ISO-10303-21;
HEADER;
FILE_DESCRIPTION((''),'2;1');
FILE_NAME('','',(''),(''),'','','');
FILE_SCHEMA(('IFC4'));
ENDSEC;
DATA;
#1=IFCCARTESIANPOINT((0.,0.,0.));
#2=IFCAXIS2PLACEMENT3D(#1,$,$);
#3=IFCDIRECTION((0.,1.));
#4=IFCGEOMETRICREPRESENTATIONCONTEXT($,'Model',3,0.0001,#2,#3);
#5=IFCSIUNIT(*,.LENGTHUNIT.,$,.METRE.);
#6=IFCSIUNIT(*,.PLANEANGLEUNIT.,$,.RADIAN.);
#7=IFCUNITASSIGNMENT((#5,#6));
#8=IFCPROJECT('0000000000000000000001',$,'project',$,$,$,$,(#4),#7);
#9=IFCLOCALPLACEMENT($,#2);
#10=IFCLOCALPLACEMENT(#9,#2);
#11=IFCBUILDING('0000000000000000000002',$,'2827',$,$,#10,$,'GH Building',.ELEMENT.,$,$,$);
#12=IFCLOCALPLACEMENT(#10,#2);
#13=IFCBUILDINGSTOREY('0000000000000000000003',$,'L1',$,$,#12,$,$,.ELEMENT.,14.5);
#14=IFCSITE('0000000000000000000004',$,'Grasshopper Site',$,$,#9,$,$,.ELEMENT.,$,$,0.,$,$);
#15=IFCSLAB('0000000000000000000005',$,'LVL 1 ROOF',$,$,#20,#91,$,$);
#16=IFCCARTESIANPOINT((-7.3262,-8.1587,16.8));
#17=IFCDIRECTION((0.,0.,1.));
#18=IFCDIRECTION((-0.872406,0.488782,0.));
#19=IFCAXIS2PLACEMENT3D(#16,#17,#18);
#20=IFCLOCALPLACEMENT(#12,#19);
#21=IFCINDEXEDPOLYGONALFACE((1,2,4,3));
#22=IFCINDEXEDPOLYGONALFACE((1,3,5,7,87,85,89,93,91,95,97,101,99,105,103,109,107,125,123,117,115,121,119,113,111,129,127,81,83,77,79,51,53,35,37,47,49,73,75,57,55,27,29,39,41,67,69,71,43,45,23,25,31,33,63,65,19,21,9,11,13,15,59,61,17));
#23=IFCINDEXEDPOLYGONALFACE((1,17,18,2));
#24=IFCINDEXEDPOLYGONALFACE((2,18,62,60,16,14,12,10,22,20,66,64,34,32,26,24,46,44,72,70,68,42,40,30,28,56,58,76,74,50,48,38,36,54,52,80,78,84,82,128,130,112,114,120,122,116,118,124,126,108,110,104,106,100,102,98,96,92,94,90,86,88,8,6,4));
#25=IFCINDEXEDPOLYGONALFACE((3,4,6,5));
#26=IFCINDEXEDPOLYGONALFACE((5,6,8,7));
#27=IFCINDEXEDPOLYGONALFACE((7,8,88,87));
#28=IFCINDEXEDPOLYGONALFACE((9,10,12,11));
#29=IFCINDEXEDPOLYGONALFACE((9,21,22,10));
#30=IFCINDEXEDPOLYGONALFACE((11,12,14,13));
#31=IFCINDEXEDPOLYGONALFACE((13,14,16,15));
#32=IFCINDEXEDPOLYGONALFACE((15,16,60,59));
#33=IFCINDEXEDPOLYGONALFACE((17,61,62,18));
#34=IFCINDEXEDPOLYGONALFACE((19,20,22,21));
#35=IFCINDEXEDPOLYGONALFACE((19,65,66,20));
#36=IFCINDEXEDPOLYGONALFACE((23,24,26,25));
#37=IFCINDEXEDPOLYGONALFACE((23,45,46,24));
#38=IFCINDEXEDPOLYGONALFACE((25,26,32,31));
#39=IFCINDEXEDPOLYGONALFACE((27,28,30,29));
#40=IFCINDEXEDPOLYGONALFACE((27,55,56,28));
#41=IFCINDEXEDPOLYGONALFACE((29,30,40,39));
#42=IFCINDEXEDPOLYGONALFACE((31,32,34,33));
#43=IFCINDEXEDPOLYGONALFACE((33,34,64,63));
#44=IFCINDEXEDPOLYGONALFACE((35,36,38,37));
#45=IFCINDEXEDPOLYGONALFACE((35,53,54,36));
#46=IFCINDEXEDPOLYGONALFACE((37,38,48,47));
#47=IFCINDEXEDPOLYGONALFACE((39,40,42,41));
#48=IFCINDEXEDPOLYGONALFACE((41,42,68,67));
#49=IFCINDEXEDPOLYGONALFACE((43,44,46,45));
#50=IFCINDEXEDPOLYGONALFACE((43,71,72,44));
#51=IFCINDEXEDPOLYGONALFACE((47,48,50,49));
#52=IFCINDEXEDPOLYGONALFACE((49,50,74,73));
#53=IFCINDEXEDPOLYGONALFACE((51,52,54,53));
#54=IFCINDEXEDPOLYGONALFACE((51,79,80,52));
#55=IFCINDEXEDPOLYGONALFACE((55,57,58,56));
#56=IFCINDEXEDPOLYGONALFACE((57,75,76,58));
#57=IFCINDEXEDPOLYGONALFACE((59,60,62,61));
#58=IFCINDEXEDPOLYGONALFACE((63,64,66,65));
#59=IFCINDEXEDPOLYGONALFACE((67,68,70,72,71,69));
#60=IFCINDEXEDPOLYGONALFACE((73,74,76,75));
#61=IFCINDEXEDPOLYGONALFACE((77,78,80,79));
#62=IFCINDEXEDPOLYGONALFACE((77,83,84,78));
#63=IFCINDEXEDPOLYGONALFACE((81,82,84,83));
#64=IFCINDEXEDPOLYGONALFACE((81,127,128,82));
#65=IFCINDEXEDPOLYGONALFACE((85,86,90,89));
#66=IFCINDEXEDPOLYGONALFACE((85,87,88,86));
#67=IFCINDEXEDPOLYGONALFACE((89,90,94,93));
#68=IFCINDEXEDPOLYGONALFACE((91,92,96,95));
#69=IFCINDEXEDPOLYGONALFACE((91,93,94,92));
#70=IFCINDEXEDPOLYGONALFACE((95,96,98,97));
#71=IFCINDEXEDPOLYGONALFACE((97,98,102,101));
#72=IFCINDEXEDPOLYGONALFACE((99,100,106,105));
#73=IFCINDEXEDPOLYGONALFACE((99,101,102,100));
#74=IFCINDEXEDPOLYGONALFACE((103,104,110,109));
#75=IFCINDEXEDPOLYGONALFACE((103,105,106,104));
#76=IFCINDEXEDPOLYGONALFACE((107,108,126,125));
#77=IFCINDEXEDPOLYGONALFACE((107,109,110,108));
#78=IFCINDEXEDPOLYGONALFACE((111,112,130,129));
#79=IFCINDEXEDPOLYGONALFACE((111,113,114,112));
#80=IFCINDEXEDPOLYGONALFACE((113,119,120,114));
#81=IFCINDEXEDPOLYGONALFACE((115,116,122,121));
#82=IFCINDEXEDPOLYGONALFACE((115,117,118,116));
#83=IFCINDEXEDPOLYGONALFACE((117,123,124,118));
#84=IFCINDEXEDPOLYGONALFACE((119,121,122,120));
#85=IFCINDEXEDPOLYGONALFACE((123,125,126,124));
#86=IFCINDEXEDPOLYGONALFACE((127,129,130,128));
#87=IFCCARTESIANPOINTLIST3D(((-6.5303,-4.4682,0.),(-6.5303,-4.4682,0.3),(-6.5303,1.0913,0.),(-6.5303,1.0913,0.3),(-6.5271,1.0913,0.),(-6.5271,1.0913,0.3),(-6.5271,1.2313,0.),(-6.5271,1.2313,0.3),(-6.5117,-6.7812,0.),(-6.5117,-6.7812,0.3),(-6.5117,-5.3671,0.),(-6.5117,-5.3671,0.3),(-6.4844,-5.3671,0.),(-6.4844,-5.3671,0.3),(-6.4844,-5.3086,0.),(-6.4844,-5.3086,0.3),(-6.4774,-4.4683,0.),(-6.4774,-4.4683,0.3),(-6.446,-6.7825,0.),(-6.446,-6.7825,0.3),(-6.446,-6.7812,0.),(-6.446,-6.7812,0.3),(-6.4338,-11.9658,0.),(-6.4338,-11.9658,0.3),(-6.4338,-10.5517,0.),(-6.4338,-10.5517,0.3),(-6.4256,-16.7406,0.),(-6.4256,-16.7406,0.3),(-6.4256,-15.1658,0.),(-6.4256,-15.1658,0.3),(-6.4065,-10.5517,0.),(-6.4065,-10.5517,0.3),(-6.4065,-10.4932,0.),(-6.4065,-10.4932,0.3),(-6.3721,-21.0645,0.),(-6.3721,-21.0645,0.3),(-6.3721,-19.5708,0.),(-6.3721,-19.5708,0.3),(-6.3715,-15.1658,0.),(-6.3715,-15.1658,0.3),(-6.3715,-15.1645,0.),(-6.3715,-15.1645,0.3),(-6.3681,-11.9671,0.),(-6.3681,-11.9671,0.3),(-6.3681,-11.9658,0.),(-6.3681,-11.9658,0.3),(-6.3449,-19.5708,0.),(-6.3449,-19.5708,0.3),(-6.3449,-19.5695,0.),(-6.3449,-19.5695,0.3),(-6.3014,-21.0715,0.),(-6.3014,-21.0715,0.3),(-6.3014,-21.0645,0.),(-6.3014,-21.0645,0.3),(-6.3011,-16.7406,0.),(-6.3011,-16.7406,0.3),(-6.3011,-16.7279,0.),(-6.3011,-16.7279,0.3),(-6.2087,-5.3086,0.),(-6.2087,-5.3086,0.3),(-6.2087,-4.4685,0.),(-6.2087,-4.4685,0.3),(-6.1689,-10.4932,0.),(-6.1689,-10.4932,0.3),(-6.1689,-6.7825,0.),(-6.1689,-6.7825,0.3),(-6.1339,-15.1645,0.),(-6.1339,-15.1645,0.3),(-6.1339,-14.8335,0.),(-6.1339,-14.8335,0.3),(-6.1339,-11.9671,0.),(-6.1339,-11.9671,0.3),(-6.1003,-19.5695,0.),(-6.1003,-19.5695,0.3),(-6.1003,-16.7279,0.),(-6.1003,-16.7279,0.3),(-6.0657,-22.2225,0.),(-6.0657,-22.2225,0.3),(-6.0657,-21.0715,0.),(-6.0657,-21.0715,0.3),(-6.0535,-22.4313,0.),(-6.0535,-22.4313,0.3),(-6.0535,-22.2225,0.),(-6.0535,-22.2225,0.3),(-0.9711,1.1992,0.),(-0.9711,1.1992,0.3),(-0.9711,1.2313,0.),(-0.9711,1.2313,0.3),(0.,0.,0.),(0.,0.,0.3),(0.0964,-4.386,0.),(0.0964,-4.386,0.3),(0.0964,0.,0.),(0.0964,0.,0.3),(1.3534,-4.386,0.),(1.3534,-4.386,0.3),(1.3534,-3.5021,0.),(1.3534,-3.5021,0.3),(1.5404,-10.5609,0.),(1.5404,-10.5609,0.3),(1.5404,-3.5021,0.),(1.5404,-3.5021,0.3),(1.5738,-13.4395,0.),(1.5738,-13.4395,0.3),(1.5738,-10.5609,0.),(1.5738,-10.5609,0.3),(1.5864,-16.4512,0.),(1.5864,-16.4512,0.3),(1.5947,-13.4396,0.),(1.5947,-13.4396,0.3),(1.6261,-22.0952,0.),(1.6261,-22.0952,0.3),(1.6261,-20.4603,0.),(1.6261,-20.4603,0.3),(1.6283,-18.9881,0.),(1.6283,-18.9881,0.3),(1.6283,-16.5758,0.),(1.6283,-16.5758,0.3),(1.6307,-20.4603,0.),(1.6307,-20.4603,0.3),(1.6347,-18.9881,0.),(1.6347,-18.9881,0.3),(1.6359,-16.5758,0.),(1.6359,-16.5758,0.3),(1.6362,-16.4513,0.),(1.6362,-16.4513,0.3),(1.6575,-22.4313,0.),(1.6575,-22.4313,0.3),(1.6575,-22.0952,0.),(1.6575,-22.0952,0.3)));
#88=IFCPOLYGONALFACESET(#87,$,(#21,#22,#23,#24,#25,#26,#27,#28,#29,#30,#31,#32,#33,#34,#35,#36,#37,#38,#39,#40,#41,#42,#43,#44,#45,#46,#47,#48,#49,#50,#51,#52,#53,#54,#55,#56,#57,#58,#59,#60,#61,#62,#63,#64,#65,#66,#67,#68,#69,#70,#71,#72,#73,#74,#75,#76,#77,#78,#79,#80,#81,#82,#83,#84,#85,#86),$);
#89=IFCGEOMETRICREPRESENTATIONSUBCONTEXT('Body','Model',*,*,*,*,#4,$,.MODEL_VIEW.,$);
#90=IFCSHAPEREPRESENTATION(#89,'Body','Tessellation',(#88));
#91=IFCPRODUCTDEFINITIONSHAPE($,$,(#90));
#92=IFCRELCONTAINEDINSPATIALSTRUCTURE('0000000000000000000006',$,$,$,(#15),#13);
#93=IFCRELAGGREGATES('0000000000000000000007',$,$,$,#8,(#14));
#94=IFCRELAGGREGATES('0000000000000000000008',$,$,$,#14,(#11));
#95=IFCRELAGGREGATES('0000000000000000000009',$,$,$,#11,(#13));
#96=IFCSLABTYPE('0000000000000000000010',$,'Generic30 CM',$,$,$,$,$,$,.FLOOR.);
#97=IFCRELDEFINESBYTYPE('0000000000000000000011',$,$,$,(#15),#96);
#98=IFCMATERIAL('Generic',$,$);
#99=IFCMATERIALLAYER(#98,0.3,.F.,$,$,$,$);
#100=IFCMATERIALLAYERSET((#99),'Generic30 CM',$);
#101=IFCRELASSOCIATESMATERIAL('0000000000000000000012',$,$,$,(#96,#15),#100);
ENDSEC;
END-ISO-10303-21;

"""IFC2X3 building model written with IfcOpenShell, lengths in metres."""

from ifc_helpers import new_model, si_unit, direction, frame, origin, place, context, subcontext, project, spatial, polyline, outline, extrude, material, layer, layer_set, layer_usage, type_object, element, save


model = new_model("IFC2X3")

# Units and contexts
model_context = context("Model", 3, precision=0.0001, world=origin(), true_north=direction((0.0, 1.0)))
body_context = subcontext(model_context, "Body", "Model", "MODEL_VIEW")
ifc_project = project(units=[si_unit("LENGTHUNIT", "METRE"), si_unit("PLANEANGLEUNIT", "RADIAN")], contexts=[model_context])

# Site, building, storey
site_placement = place(None, origin())
site = spatial("IfcSite", under=ifc_project, at=site_placement, Name="Grasshopper Site", CompositionType="ELEMENT", RefElevation=0.0)
building_placement = place(site_placement, origin())
building = spatial("IfcBuilding", under=site, at=building_placement, Name="2827", LongName="GH Building", CompositionType="ELEMENT")
storey_placement = place(building_placement, origin())
storey = spatial("IfcBuildingStorey", under=building, at=storey_placement, Name="L1", CompositionType="ELEMENT", Elevation=14.5)

# Slab
ifc_material_1 = material(Name="Generic")
ifc_layer_1 = layer(ifc_material_1, 0.3, ventilated=False)
ifc_layer_set_1 = layer_set([ifc_layer_1], Name="Generic30 CM")
ifc_layer_usage_1 = layer_usage(ifc_layer_set_1, "AXIS3", "NEGATIVE", -0.3)
slab_type_1 = type_object("IfcSlabType", Name="Generic30 CM", PredefinedType="FLOOR", material=ifc_layer_set_1)
slab_1_placement = place(storey_placement, frame((-7.3262, -8.1587, 16.8), z_axis=(0.0, 0.0, 1.0), x_axis=(-0.872406, 0.488782, 0.0)))
element("IfcSlab", 1, at=slab_1_placement, inside=storey, type_object=slab_type_1, material=ifc_layer_usage_1, Name="LVL 1 ROOF", context=body_context, shape_type="SweptSolid", body=[
    extrude(outline(polyline([(0.0, 0.0), (0.0964, 0.0), (0.0964, -4.386), (1.3534, -4.386), (1.3534, -3.5021), (1.5404, -3.5021), (1.5404, -10.5609), (1.5738, -10.5609), (1.5738, -13.4395), (1.5947, -13.4396), (1.5864, -16.4512), (1.6362, -16.4513), (1.6359, -16.5758), (1.6283, -16.5758), (1.6283, -18.9881), (1.6347, -18.9881), (1.6307, -20.4603), (1.6261, -20.4603), (1.6261, -22.0952), (1.6575, -22.0952), (1.6575, -22.4313), (-6.0535, -22.4313), (-6.0535, -22.2225), (-6.0657, -22.2225), (-6.0657, -21.0715), (-6.3014, -21.0715), (-6.3014, -21.0645), (-6.3721, -21.0645), (-6.3721, -19.5708), (-6.3449, -19.5708), (-6.3449, -19.5695), (-6.1003, -19.5695), (-6.1003, -16.7279), (-6.3011, -16.7279), (-6.3011, -16.7406), (-6.4256, -16.7406), (-6.4256, -15.1658), (-6.3715, -15.1658), (-6.3715, -15.1645), (-6.1339, -15.1645), (-6.1339, -14.8335), (-6.1339, -11.9671), (-6.3681, -11.9671), (-6.3681, -11.9658), (-6.4337, -11.9658), (-6.4337, -10.5517), (-6.4065, -10.5517), (-6.4065, -10.4932), (-6.1689, -10.4932), (-6.1689, -6.7825), (-6.446, -6.7825), (-6.446, -6.7812), (-6.5117, -6.7812), (-6.5117, -5.3671), (-6.4844, -5.3671), (-6.4844, -5.3086), (-6.2087, -5.3086), (-6.2087, -4.4685), (-6.4774, -4.4683), (-6.5303, -4.4682), (-6.5303, 1.0913), (-6.5271, 1.0913), (-6.5271, 1.2313), (-0.9711, 1.2313), (-0.9711, 1.1992), (0.0, 0.0)])), origin(), (0.0, 0.0, 1.0), 0.3),
])

save(model, "model.ifc")
